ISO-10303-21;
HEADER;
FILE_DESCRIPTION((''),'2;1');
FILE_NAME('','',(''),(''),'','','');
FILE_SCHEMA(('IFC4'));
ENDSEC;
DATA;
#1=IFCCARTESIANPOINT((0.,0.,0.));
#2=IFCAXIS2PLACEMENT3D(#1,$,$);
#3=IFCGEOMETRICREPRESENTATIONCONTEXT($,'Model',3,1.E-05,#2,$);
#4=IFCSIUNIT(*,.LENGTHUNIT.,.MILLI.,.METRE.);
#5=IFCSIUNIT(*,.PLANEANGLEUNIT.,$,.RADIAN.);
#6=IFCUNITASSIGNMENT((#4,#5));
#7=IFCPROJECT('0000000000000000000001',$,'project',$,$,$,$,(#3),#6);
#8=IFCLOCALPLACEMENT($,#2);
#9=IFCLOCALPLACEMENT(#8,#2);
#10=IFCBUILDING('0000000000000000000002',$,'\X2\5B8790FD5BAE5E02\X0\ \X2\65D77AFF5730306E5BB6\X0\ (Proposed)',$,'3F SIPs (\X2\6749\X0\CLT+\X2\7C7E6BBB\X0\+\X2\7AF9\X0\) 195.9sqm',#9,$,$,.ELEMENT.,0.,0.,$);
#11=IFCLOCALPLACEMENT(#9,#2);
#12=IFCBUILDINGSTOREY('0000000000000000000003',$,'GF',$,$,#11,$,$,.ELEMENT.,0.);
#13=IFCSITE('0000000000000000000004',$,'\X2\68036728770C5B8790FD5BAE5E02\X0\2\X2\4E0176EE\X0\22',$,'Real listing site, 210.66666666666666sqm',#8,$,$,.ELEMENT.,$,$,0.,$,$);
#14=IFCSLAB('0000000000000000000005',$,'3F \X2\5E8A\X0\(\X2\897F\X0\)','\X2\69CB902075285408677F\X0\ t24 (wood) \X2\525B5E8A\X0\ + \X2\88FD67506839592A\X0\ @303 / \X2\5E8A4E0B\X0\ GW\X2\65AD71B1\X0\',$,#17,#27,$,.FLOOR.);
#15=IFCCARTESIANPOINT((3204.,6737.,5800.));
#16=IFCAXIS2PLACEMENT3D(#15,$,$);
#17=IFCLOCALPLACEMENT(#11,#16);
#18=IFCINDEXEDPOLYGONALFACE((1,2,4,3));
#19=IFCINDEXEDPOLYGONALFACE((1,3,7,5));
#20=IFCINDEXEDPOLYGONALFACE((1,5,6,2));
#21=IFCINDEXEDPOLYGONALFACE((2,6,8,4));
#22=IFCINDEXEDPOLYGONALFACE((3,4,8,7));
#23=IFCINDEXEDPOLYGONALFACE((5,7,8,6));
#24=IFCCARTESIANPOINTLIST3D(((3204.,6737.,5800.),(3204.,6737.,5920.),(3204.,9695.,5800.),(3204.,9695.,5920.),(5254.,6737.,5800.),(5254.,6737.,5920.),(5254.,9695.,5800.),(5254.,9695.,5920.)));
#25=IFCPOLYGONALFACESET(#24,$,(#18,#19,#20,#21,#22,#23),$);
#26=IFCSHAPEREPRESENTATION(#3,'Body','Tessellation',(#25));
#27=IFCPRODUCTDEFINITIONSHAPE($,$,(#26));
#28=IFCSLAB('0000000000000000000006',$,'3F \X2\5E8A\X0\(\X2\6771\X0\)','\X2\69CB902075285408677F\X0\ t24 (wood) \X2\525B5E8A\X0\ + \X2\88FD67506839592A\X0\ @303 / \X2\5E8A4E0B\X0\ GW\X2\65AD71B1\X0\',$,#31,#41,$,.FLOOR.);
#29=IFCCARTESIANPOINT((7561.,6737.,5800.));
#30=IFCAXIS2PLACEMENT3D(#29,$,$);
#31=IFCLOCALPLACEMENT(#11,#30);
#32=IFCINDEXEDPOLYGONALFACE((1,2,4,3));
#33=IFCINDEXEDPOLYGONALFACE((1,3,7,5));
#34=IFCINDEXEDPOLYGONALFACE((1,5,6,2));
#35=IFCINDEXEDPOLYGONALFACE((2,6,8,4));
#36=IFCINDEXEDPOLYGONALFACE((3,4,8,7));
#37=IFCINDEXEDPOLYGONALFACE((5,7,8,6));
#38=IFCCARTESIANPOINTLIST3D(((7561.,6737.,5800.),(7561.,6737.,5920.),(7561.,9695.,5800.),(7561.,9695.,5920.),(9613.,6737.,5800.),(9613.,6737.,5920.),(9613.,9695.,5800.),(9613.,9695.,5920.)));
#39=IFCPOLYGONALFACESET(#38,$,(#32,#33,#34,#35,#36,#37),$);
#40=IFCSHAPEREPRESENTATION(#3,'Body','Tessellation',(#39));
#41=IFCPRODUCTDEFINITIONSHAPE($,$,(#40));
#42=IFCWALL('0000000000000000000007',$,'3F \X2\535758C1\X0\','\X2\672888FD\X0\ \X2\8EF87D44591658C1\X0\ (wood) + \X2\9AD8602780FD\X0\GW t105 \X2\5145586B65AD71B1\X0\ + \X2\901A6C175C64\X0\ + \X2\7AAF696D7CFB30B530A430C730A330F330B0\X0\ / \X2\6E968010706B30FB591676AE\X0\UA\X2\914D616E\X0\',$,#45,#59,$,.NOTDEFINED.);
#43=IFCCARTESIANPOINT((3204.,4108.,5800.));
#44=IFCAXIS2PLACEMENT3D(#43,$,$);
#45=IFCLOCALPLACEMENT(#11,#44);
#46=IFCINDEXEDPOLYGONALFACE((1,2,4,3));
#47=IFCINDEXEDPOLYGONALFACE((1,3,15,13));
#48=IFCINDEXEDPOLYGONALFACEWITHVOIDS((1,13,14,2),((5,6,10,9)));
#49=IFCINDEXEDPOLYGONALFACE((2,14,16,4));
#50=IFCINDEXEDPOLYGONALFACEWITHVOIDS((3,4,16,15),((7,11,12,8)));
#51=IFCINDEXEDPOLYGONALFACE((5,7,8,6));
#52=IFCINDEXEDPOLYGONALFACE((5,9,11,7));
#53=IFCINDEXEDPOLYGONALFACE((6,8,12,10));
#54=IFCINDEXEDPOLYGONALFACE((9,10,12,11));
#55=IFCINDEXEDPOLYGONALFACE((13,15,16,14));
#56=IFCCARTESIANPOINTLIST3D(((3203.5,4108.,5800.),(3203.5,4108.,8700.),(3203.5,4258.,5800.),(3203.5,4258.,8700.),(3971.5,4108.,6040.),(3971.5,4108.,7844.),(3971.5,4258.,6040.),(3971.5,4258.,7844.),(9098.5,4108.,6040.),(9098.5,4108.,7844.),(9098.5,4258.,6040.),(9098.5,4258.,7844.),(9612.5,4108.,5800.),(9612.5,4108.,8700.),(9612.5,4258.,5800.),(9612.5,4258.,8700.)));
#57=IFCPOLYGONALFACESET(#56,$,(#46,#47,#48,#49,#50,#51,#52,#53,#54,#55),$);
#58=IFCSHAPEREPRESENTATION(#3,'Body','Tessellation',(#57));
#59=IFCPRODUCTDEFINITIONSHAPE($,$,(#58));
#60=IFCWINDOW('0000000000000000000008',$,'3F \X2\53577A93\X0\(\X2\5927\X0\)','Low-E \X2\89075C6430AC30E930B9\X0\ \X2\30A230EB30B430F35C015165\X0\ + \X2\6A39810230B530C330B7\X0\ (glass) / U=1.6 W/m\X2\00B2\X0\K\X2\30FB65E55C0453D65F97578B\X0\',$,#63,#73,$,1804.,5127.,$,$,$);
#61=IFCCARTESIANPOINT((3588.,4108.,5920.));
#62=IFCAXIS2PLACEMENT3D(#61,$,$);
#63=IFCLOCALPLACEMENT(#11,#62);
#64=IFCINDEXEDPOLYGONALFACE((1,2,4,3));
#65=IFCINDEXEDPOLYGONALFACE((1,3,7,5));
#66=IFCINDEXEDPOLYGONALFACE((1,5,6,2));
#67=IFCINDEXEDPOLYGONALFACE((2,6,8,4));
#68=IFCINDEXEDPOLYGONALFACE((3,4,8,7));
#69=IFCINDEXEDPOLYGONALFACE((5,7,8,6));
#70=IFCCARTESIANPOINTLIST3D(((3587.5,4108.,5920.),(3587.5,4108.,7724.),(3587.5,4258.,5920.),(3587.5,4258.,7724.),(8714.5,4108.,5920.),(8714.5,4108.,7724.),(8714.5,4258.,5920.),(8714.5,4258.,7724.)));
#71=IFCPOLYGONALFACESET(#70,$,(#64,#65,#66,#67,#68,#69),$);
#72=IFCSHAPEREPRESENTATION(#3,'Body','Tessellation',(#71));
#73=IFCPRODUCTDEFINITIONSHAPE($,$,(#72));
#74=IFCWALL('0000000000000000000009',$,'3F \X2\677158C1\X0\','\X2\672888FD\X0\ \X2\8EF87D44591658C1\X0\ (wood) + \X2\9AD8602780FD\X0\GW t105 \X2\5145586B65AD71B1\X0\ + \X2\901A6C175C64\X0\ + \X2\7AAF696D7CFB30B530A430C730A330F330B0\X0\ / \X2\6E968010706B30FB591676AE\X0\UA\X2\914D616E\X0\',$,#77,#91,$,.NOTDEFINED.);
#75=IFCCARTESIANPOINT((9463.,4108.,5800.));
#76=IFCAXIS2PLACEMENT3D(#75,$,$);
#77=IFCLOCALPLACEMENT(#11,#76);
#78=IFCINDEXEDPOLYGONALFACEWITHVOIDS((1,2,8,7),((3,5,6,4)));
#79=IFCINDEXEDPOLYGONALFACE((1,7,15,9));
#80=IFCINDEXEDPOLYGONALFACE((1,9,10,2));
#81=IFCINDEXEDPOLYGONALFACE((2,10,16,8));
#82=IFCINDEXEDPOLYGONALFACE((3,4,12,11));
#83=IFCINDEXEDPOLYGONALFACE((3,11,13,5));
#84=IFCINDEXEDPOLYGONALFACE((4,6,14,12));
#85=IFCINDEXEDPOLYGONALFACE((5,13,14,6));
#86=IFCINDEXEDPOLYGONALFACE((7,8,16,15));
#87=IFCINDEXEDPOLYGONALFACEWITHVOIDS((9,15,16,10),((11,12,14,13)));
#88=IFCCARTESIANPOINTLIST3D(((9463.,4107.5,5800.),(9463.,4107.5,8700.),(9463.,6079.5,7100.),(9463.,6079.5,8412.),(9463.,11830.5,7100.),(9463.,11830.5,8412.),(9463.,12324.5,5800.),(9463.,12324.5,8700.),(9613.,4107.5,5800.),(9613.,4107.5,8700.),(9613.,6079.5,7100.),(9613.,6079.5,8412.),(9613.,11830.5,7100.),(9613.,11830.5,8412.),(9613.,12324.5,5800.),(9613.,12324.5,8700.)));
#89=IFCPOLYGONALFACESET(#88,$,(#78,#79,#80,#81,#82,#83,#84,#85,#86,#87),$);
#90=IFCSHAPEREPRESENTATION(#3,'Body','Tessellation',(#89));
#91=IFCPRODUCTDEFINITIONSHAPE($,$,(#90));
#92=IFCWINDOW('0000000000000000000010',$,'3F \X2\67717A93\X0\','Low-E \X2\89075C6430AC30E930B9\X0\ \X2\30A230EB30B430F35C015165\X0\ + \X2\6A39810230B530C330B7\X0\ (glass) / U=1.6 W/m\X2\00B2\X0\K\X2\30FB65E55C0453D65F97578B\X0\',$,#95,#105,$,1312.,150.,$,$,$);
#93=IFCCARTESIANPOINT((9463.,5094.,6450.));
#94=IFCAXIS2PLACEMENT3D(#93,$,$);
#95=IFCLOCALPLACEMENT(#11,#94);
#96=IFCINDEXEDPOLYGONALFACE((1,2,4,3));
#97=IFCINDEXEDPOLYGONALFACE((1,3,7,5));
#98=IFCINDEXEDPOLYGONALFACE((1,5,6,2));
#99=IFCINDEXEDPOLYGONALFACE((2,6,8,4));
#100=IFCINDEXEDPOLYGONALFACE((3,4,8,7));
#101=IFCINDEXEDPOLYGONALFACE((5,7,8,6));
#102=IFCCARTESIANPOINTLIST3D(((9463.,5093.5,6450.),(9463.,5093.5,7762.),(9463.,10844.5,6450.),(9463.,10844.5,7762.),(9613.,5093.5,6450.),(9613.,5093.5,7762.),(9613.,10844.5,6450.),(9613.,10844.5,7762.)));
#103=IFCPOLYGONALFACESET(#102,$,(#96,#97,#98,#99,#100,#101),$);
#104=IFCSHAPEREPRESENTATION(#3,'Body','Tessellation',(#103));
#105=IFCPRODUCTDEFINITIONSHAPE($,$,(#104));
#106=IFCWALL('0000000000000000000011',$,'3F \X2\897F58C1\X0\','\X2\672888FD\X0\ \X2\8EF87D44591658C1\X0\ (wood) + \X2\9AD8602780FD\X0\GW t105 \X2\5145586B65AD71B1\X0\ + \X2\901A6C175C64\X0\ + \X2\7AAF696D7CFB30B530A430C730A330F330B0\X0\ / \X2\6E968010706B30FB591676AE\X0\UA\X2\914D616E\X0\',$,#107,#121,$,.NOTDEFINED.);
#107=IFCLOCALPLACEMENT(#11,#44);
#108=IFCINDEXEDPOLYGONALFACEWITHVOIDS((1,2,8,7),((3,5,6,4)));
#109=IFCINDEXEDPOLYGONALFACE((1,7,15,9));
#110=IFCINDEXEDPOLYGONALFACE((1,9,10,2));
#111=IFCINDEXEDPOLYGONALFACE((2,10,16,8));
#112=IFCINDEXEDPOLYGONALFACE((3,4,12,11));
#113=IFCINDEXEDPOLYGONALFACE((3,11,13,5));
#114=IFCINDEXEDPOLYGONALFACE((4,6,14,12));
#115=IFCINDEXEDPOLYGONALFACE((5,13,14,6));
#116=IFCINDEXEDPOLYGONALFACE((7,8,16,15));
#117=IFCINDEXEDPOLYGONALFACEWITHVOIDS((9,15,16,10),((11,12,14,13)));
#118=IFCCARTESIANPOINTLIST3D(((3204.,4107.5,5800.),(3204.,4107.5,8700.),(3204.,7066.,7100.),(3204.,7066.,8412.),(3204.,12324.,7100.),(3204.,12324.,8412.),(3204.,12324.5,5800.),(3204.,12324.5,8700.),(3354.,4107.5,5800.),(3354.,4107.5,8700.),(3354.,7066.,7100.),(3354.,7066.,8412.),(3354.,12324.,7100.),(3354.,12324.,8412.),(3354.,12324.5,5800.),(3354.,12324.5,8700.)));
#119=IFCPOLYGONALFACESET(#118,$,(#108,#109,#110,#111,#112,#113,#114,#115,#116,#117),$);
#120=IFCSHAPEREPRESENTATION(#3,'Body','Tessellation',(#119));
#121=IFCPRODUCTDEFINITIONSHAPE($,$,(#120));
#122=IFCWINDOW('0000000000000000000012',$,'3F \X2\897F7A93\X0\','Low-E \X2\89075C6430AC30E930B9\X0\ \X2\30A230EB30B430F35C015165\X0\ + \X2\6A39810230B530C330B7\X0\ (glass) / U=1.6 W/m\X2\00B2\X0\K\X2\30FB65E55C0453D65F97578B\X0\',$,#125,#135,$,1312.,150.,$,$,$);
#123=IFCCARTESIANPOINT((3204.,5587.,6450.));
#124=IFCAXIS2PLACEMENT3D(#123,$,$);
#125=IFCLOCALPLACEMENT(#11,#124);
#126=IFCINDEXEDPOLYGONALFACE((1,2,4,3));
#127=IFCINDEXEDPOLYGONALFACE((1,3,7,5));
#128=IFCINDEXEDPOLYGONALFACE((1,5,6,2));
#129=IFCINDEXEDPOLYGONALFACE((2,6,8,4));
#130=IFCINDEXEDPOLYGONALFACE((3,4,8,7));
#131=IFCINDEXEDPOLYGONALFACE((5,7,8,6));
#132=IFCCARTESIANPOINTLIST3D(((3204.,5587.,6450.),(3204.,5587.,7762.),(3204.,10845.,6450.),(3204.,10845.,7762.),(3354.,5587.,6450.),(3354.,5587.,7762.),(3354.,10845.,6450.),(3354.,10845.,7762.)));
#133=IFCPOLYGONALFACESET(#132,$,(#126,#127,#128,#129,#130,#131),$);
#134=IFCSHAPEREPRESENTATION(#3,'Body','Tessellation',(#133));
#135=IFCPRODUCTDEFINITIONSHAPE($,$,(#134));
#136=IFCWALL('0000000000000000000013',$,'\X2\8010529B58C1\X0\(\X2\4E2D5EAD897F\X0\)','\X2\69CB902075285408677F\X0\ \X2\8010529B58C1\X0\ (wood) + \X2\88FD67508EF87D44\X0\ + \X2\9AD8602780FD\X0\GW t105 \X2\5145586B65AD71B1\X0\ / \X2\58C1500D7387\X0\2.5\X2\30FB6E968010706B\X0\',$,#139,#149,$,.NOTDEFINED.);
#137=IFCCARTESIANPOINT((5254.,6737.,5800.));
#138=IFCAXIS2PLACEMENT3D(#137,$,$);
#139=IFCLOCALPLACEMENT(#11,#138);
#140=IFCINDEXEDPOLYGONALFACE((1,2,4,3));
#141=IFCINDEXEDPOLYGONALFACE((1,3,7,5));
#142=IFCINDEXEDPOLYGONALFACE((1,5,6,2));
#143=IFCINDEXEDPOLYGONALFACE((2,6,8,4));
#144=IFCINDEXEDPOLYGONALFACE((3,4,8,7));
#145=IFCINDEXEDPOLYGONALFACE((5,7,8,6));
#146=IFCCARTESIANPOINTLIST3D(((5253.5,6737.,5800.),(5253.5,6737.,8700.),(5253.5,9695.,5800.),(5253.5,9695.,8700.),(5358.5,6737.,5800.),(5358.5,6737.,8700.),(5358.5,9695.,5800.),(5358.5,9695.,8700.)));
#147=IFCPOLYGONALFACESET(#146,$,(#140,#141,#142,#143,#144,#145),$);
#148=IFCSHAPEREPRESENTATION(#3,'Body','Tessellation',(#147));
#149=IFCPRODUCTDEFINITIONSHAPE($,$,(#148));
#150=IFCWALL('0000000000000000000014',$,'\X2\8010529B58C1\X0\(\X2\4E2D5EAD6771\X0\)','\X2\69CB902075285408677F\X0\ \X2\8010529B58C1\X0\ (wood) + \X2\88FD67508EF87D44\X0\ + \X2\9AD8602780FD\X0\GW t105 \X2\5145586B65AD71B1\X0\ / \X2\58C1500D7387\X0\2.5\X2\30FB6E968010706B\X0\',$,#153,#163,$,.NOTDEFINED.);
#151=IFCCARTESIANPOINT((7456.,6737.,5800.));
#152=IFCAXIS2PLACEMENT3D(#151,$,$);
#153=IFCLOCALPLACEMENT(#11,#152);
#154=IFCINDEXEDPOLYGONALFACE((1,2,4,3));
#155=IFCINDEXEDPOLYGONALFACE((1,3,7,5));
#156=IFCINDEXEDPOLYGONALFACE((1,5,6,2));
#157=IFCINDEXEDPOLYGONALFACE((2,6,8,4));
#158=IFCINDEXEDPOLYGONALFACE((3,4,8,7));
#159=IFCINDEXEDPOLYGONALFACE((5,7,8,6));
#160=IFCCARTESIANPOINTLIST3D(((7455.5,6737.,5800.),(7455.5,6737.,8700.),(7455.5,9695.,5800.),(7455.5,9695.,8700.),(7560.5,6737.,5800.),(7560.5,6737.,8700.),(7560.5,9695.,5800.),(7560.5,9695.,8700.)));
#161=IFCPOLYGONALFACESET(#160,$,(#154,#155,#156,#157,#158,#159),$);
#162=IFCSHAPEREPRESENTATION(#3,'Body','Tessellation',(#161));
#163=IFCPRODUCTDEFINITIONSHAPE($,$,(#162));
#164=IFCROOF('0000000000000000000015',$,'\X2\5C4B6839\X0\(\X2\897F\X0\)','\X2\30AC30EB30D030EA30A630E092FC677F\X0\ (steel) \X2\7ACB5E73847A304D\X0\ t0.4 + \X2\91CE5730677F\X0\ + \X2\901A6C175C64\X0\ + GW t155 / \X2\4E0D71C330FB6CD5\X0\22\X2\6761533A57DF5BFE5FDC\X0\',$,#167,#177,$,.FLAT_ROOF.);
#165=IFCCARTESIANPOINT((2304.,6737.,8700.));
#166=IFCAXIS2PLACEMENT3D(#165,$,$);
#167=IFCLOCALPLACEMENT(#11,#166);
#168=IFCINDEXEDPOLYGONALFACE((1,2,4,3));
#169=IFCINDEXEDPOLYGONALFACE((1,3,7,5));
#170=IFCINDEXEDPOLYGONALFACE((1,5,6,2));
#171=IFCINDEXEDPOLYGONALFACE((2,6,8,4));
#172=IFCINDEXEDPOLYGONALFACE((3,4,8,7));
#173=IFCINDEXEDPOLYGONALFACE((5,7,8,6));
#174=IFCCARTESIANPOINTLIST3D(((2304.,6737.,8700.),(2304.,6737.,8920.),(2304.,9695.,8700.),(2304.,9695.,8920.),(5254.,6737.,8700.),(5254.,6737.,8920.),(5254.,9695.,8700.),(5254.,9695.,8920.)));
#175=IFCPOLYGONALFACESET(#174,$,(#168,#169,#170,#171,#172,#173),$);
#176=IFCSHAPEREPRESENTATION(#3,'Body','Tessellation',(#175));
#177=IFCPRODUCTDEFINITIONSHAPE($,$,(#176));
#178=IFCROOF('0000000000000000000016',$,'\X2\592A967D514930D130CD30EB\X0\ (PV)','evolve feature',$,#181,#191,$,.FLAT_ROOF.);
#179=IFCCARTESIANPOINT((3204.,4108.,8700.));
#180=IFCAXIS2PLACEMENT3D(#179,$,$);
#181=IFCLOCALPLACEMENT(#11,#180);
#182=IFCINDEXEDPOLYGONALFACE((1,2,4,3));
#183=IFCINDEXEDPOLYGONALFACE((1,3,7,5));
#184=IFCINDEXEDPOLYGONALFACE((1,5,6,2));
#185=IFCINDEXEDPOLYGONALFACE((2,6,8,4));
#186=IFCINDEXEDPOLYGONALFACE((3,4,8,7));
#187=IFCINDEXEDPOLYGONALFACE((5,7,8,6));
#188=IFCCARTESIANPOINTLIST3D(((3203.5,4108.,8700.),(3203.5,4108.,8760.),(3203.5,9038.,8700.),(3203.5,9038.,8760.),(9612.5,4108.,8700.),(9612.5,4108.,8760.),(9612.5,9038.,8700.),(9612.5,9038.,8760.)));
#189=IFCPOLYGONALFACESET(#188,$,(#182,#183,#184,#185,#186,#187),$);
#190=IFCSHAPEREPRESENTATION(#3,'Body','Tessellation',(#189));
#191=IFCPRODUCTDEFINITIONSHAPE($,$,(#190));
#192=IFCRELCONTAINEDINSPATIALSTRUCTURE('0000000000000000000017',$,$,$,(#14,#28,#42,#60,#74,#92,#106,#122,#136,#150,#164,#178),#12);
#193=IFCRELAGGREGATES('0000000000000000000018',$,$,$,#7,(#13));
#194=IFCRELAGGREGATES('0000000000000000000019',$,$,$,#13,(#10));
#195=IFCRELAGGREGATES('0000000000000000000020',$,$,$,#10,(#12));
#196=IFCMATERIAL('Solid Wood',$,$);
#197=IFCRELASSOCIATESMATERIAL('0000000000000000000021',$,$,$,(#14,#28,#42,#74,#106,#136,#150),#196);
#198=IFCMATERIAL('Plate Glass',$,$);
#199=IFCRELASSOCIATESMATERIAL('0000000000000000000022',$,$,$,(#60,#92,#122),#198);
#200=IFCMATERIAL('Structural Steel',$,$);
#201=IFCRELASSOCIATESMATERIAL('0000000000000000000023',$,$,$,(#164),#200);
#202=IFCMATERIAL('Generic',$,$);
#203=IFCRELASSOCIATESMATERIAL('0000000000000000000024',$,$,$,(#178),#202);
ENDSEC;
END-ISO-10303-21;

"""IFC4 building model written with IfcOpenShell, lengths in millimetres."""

from ifc_helpers import new_model, si_unit, frame, frame_2d, origin, place, context, project, spatial, rectangle, extrude, material, element, fill, save


model = new_model("IFC4")

# Units and contexts
model_context = context("Model", 3, precision=1e-05, world=origin())
ifc_project = project(units=[si_unit("LENGTHUNIT", "METRE", prefix="MILLI"), si_unit("PLANEANGLEUNIT", "RADIAN")], contexts=[model_context])

# Site, building, storey
site_placement = place(None, origin())
site = spatial("IfcSite", under=ifc_project, at=site_placement, Name="栃木県宇都宮市2丁目22", ObjectType="Real listing site, 210.66666666666666sqm", CompositionType="ELEMENT", RefElevation=0.0)
building_placement = place(site_placement, origin())
building = spatial("IfcBuilding", under=site, at=building_placement, Name="宇都宮市 旗竿地の家 (Proposed)", ObjectType="3F SIPs (杉CLT+籾殻+竹) 195.9sqm", CompositionType="ELEMENT", ElevationOfRefHeight=0.0, ElevationOfTerrain=0.0)
storey_placement = place(building_placement, origin())
storey = spatial("IfcBuildingStorey", under=building, at=storey_placement, Name="GF", CompositionType="ELEMENT", Elevation=0.0)

# Slabs
ifc_material_1 = material(Name="Solid Wood")
slab_1_placement = place(storey_placement, frame((3204.0, 6737.0, 5800.0)))
element("IfcSlab", 1, at=slab_1_placement, inside=storey, material=ifc_material_1, Name="3F 床(西)", Description="構造用合板 t24 (wood) 剛床 + 製材根太 @303 / 床下 GW断熱", PredefinedType="FLOOR", context=model_context, shape_type="SweptSolid", body=[
    extrude(rectangle(XDim=2050.0, YDim=2958.0, at=frame_2d((1025.0, 1479.0))), frame((3204.0, 6737.0, 5800.0)), (0.0, 0.0, 1.0), 120.0),
])
slab_2_placement = place(storey_placement, frame((7561.0, 6737.0, 5800.0)))
element("IfcSlab", 2, at=slab_2_placement, inside=storey, material=ifc_material_1, Name="3F 床(東)", Description="構造用合板 t24 (wood) 剛床 + 製材根太 @303 / 床下 GW断熱", PredefinedType="FLOOR", context=model_context, shape_type="SweptSolid", body=[
    extrude(rectangle(XDim=2052.0, YDim=2958.0, at=frame_2d((1026.0, 1479.0))), frame((7561.0, 6737.0, 5800.0)), (0.0, 0.0, 1.0), 120.0),
])

# Walls, openings, windows
wall_1_placement = place(storey_placement, frame((3204.0, 4108.0, 5800.0)))
wall_1 = element("IfcWall", 3, at=wall_1_placement, inside=storey, material=ifc_material_1, Name="3F 南壁", Description="木製 軸組外壁 (wood) + 高性能GW t105 充填断熱 + 通気層 + 窯業系サイディング / 準耐火・外皮UA配慮", PredefinedType="NOTDEFINED", context=model_context, shape_type="SweptSolid", body=[
    extrude(rectangle(XDim=6409.0, YDim=150.0, at=frame_2d((3204.0, 75.0))), frame((3204.0, 4108.0, 5800.0)), (0.0, 0.0, 1.0), 2900.0),
])
opening_1_placement = place(storey_placement, frame((3588.0, 4108.0, 5920.0)))
opening_1 = element("IfcOpeningElement", 4, at=opening_1_placement, cuts=wall_1, PredefinedType="NOTDEFINED", context=model_context, shape_type="SweptSolid", body=[
    extrude(rectangle(XDim=5127.0, YDim=150.0, at=frame_2d((2563.0, 75.0))), frame((3588.0, 4108.0, 5920.0)), (0.0, 0.0, 1.0), 1804.0),
])
ifc_material_2 = material(Name="Plate Glass")
window_1_placement = place(storey_placement, frame((3588.0, 4108.0, 5920.0)))
window_1 = element("IfcWindow", 5, at=window_1_placement, inside=storey, material=ifc_material_2, Name="3F 南窓(大)", Description="Low-E 複層ガラス アルゴン封入 + 樹脂サッシ (glass) / U=1.6 W/m²K・日射取得型", OverallHeight=1804.0, OverallWidth=5127.0, context=model_context, shape_type="SweptSolid", body=[
    extrude(rectangle(XDim=5127.0, YDim=150.0, at=frame_2d((2563.0, 75.0))), frame((3588.0, 4108.0, 5920.0)), (0.0, 0.0, 1.0), 1804.0),
])
fill(opening_1, window_1)
wall_2_placement = place(storey_placement, frame((9463.0, 4108.0, 5800.0)))
wall_2 = element("IfcWall", 6, at=wall_2_placement, inside=storey, material=ifc_material_1, Name="3F 東壁", Description="木製 軸組外壁 (wood) + 高性能GW t105 充填断熱 + 通気層 + 窯業系サイディング / 準耐火・外皮UA配慮", PredefinedType="NOTDEFINED", context=model_context, shape_type="SweptSolid", body=[
    extrude(rectangle(XDim=150.0, YDim=8217.0, at=frame_2d((75.0, 4108.0))), frame((9463.0, 4108.0, 5800.0)), (0.0, 0.0, 1.0), 2900.0),
])
opening_2_placement = place(storey_placement, frame((9463.0, 5094.0, 6450.0)))
opening_2 = element("IfcOpeningElement", 7, at=opening_2_placement, cuts=wall_2, PredefinedType="NOTDEFINED", context=model_context, shape_type="SweptSolid", body=[
    extrude(rectangle(XDim=150.0, YDim=5751.0, at=frame_2d((75.0, 2875.0))), frame((9463.0, 5094.0, 6450.0)), (0.0, 0.0, 1.0), 1312.0),
])
window_2_placement = place(storey_placement, frame((9463.0, 5094.0, 6450.0)))
window_2 = element("IfcWindow", 8, at=window_2_placement, inside=storey, material=ifc_material_2, Name="3F 東窓", Description="Low-E 複層ガラス アルゴン封入 + 樹脂サッシ (glass) / U=1.6 W/m²K・日射取得型", OverallHeight=1312.0, OverallWidth=150.0, context=model_context, shape_type="SweptSolid", body=[
    extrude(rectangle(XDim=150.0, YDim=5751.0, at=frame_2d((75.0, 2875.0))), frame((9463.0, 5094.0, 6450.0)), (0.0, 0.0, 1.0), 1312.0),
])
fill(opening_2, window_2)
wall_3_placement = place(storey_placement, frame((3204.0, 4108.0, 5800.0)))
wall_3 = element("IfcWall", 9, at=wall_3_placement, inside=storey, material=ifc_material_1, Name="3F 西壁", Description="木製 軸組外壁 (wood) + 高性能GW t105 充填断熱 + 通気層 + 窯業系サイディング / 準耐火・外皮UA配慮", PredefinedType="NOTDEFINED", context=model_context, shape_type="SweptSolid", body=[
    extrude(rectangle(XDim=150.0, YDim=8217.0, at=frame_2d((75.0, 4108.0))), frame((3204.0, 4108.0, 5800.0)), (0.0, 0.0, 1.0), 2900.0),
])
opening_3_placement = place(storey_placement, frame((3204.0, 5587.0, 6450.0)))
opening_3 = element("IfcOpeningElement", 10, at=opening_3_placement, cuts=wall_3, PredefinedType="NOTDEFINED", context=model_context, shape_type="SweptSolid", body=[
    extrude(rectangle(XDim=150.0, YDim=5258.0, at=frame_2d((75.0, 2629.0))), frame((3204.0, 5587.0, 6450.0)), (0.0, 0.0, 1.0), 1312.0),
])
window_3_placement = place(storey_placement, frame((3204.0, 5587.0, 6450.0)))
window_3 = element("IfcWindow", 11, at=window_3_placement, inside=storey, material=ifc_material_2, Name="3F 西窓", Description="Low-E 複層ガラス アルゴン封入 + 樹脂サッシ (glass) / U=1.6 W/m²K・日射取得型", OverallHeight=1312.0, OverallWidth=150.0, context=model_context, shape_type="SweptSolid", body=[
    extrude(rectangle(XDim=150.0, YDim=5258.0, at=frame_2d((75.0, 2629.0))), frame((3204.0, 5587.0, 6450.0)), (0.0, 0.0, 1.0), 1312.0),
])
fill(opening_3, window_3)

# Walls
wall_4_placement = place(storey_placement, frame((5254.0, 6737.0, 5800.0)))
element("IfcWall", 12, at=wall_4_placement, inside=storey, material=ifc_material_1, Name="耐力壁(中庭西)", Description="構造用合板 耐力壁 (wood) + 製材軸組 + 高性能GW t105 充填断熱 / 壁倍率2.5・準耐火", PredefinedType="NOTDEFINED", context=model_context, shape_type="SweptSolid", body=[
    extrude(rectangle(XDim=105.0, YDim=2958.0, at=frame_2d((52.0, 1479.0))), frame((5254.0, 6737.0, 5800.0)), (0.0, 0.0, 1.0), 2900.0),
])
wall_5_placement = place(storey_placement, frame((7456.0, 6737.0, 5800.0)))
element("IfcWall", 13, at=wall_5_placement, inside=storey, material=ifc_material_1, Name="耐力壁(中庭東)", Description="構造用合板 耐力壁 (wood) + 製材軸組 + 高性能GW t105 充填断熱 / 壁倍率2.5・準耐火", PredefinedType="NOTDEFINED", context=model_context, shape_type="SweptSolid", body=[
    extrude(rectangle(XDim=105.0, YDim=2958.0, at=frame_2d((52.0, 1479.0))), frame((7456.0, 6737.0, 5800.0)), (0.0, 0.0, 1.0), 2900.0),
])

# Roofs
ifc_material_3 = material(Name="Structural Steel")
roof_1_placement = place(storey_placement, frame((2304.0, 6737.0, 8700.0)))
element("IfcRoof", 14, at=roof_1_placement, inside=storey, material=ifc_material_3, Name="屋根(西)", Description="ガルバリウム鋼板 (steel) 立平葺き t0.4 + 野地板 + 通気層 + GW t155 / 不燃・法22条区域対応", PredefinedType="FLAT_ROOF", context=model_context, shape_type="SweptSolid", body=[
    extrude(rectangle(XDim=2950.0, YDim=2958.0, at=frame_2d((1475.0, 1479.0))), frame((2304.0, 6737.0, 8700.0)), (0.0, 0.0, 1.0), 220.0),
])
ifc_material_4 = material(Name="Generic")
roof_2_placement = place(storey_placement, frame((3204.0, 4108.0, 8700.0)))
element("IfcRoof", 15, at=roof_2_placement, inside=storey, material=ifc_material_4, Name="太陽光パネル (PV)", Description="evolve feature", PredefinedType="FLAT_ROOF", context=model_context, shape_type="SweptSolid", body=[
    extrude(rectangle(XDim=6409.0, YDim=4930.0, at=frame_2d((3204.0, 2465.0))), frame((3204.0, 4108.0, 8700.0)), (0.0, 0.0, 1.0), 60.0),
])

save(model, "model.ifc")
